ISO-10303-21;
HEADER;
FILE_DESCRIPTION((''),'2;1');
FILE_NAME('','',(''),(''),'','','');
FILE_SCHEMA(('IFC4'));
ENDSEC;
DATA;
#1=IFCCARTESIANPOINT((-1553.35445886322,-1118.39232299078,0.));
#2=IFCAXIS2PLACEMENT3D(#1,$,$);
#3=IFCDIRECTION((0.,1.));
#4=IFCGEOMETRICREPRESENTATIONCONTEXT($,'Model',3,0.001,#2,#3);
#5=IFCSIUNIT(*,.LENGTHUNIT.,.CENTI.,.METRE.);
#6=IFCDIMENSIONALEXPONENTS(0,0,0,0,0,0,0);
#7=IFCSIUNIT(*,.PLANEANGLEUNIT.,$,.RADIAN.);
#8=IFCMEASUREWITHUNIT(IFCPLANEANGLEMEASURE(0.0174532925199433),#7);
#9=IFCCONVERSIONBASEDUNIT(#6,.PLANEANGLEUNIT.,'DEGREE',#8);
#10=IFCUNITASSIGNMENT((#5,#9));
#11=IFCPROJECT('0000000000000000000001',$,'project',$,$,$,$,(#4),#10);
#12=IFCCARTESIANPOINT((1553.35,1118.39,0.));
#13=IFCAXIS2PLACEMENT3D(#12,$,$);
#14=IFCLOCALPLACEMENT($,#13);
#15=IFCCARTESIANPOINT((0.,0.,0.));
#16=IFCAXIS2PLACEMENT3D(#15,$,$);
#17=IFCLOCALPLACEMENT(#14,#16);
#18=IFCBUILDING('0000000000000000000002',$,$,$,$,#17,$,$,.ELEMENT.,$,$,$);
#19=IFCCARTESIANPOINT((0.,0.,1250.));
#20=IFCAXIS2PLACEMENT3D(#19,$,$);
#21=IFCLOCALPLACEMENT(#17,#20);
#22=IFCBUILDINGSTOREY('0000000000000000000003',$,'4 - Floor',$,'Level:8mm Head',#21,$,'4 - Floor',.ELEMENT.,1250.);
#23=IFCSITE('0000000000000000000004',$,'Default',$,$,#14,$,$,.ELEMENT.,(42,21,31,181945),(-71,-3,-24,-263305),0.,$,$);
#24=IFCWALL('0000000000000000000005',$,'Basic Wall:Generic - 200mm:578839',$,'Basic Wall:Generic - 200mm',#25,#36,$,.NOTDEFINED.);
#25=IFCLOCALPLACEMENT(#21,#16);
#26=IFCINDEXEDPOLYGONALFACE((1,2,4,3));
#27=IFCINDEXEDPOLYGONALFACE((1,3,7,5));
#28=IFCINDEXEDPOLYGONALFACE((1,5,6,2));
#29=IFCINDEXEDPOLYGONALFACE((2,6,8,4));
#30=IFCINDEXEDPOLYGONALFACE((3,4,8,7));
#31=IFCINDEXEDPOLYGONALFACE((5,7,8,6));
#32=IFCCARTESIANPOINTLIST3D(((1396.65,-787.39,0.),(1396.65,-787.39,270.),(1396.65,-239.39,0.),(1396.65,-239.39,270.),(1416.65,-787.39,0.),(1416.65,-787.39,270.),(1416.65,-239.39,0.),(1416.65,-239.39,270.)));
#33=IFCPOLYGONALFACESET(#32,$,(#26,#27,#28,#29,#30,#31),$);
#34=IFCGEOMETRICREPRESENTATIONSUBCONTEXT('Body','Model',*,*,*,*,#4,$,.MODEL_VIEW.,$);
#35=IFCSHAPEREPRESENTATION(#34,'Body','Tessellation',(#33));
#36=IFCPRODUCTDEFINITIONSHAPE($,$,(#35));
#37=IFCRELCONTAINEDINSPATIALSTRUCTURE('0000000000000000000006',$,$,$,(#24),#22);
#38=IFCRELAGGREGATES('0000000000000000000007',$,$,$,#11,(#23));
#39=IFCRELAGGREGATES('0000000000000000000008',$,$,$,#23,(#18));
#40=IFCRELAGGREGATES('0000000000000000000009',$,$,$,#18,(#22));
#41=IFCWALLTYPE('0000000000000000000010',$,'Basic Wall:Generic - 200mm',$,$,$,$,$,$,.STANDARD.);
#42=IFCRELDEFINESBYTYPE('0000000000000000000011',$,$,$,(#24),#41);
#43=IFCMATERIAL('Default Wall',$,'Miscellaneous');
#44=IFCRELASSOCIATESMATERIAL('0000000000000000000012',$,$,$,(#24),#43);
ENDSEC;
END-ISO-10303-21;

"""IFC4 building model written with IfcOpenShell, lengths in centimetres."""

from ifc_helpers import new_model, entity, si_unit, converted_unit, direction, frame, origin, place, context, subcontext, project, spatial, indexed_curve, outline, extrude, material, type_object, element, save


model = new_model("IFC4")

# Units and contexts
model_context = context("Model", 3, precision=0.001, world=frame((-1553.35445886322, -1118.39232299078, 0.0)), true_north=direction((0.0, 1.0)))
body_context = subcontext(model_context, "Body", "Model", "MODEL_VIEW")
ifc_project = project(units=[si_unit("LENGTHUNIT", "METRE", prefix="CENTI"), converted_unit("PLANEANGLEUNIT", "DEGREE", entity("IfcPlaneAngleMeasure", 0.0174532925199433), si_unit("PLANEANGLEUNIT", "RADIAN"), dimensions=[0, 0, 0, 0, 0, 0, 0])], contexts=[model_context])

# Site, building, storey
site_placement = place(None, frame((1553.35, 1118.39, 0.0)))
site = spatial("IfcSite", under=ifc_project, at=site_placement, Name="Default", CompositionType="ELEMENT", RefLatitude=(42, 21, 31, 181945), RefLongitude=(-71, -3, -24, -263305), RefElevation=0.0)
building_placement = place(site_placement, origin())
building = spatial("IfcBuilding", under=site, at=building_placement, CompositionType="ELEMENT")
storey_placement = place(building_placement, frame((0.0, 0.0, 1250.0)))
storey = spatial("IfcBuildingStorey", under=building, at=storey_placement, Name="4 - Floor", ObjectType="Level:8mm Head", LongName="4 - Floor", CompositionType="ELEMENT", Elevation=1250.0)

# Wall
ifc_material_1 = material(Name="Default Wall", Category="Miscellaneous")
wall_type_1 = type_object("IfcWallType", Name="Basic Wall:Generic - 200mm", PredefinedType="STANDARD")
wall_1_placement = place(storey_placement, frame((1406.65, -239.39, 0.0), z_axis=(0.0, 0.0, 1.0), x_axis=(0.0, -1.0, 0.0)))
element("IfcWall", 1, at=wall_1_placement, inside=storey, type_object=wall_type_1, material=ifc_material_1, Name="Basic Wall:Generic - 200mm:578839", ObjectType="Basic Wall:Generic - 200mm", PredefinedType="NOTDEFINED", context=body_context, shape_type="SweptSolid", body=[
    extrude(outline(indexed_curve([(548.0, 10.0), (0.0, 10.0), (0.0, -10.0), (548.0, -10.0), (548.0, 10.0)], self_intersect=False)), origin(), (0.0, 0.0, 1.0), 270.0),
])

save(model, "model.ifc")
